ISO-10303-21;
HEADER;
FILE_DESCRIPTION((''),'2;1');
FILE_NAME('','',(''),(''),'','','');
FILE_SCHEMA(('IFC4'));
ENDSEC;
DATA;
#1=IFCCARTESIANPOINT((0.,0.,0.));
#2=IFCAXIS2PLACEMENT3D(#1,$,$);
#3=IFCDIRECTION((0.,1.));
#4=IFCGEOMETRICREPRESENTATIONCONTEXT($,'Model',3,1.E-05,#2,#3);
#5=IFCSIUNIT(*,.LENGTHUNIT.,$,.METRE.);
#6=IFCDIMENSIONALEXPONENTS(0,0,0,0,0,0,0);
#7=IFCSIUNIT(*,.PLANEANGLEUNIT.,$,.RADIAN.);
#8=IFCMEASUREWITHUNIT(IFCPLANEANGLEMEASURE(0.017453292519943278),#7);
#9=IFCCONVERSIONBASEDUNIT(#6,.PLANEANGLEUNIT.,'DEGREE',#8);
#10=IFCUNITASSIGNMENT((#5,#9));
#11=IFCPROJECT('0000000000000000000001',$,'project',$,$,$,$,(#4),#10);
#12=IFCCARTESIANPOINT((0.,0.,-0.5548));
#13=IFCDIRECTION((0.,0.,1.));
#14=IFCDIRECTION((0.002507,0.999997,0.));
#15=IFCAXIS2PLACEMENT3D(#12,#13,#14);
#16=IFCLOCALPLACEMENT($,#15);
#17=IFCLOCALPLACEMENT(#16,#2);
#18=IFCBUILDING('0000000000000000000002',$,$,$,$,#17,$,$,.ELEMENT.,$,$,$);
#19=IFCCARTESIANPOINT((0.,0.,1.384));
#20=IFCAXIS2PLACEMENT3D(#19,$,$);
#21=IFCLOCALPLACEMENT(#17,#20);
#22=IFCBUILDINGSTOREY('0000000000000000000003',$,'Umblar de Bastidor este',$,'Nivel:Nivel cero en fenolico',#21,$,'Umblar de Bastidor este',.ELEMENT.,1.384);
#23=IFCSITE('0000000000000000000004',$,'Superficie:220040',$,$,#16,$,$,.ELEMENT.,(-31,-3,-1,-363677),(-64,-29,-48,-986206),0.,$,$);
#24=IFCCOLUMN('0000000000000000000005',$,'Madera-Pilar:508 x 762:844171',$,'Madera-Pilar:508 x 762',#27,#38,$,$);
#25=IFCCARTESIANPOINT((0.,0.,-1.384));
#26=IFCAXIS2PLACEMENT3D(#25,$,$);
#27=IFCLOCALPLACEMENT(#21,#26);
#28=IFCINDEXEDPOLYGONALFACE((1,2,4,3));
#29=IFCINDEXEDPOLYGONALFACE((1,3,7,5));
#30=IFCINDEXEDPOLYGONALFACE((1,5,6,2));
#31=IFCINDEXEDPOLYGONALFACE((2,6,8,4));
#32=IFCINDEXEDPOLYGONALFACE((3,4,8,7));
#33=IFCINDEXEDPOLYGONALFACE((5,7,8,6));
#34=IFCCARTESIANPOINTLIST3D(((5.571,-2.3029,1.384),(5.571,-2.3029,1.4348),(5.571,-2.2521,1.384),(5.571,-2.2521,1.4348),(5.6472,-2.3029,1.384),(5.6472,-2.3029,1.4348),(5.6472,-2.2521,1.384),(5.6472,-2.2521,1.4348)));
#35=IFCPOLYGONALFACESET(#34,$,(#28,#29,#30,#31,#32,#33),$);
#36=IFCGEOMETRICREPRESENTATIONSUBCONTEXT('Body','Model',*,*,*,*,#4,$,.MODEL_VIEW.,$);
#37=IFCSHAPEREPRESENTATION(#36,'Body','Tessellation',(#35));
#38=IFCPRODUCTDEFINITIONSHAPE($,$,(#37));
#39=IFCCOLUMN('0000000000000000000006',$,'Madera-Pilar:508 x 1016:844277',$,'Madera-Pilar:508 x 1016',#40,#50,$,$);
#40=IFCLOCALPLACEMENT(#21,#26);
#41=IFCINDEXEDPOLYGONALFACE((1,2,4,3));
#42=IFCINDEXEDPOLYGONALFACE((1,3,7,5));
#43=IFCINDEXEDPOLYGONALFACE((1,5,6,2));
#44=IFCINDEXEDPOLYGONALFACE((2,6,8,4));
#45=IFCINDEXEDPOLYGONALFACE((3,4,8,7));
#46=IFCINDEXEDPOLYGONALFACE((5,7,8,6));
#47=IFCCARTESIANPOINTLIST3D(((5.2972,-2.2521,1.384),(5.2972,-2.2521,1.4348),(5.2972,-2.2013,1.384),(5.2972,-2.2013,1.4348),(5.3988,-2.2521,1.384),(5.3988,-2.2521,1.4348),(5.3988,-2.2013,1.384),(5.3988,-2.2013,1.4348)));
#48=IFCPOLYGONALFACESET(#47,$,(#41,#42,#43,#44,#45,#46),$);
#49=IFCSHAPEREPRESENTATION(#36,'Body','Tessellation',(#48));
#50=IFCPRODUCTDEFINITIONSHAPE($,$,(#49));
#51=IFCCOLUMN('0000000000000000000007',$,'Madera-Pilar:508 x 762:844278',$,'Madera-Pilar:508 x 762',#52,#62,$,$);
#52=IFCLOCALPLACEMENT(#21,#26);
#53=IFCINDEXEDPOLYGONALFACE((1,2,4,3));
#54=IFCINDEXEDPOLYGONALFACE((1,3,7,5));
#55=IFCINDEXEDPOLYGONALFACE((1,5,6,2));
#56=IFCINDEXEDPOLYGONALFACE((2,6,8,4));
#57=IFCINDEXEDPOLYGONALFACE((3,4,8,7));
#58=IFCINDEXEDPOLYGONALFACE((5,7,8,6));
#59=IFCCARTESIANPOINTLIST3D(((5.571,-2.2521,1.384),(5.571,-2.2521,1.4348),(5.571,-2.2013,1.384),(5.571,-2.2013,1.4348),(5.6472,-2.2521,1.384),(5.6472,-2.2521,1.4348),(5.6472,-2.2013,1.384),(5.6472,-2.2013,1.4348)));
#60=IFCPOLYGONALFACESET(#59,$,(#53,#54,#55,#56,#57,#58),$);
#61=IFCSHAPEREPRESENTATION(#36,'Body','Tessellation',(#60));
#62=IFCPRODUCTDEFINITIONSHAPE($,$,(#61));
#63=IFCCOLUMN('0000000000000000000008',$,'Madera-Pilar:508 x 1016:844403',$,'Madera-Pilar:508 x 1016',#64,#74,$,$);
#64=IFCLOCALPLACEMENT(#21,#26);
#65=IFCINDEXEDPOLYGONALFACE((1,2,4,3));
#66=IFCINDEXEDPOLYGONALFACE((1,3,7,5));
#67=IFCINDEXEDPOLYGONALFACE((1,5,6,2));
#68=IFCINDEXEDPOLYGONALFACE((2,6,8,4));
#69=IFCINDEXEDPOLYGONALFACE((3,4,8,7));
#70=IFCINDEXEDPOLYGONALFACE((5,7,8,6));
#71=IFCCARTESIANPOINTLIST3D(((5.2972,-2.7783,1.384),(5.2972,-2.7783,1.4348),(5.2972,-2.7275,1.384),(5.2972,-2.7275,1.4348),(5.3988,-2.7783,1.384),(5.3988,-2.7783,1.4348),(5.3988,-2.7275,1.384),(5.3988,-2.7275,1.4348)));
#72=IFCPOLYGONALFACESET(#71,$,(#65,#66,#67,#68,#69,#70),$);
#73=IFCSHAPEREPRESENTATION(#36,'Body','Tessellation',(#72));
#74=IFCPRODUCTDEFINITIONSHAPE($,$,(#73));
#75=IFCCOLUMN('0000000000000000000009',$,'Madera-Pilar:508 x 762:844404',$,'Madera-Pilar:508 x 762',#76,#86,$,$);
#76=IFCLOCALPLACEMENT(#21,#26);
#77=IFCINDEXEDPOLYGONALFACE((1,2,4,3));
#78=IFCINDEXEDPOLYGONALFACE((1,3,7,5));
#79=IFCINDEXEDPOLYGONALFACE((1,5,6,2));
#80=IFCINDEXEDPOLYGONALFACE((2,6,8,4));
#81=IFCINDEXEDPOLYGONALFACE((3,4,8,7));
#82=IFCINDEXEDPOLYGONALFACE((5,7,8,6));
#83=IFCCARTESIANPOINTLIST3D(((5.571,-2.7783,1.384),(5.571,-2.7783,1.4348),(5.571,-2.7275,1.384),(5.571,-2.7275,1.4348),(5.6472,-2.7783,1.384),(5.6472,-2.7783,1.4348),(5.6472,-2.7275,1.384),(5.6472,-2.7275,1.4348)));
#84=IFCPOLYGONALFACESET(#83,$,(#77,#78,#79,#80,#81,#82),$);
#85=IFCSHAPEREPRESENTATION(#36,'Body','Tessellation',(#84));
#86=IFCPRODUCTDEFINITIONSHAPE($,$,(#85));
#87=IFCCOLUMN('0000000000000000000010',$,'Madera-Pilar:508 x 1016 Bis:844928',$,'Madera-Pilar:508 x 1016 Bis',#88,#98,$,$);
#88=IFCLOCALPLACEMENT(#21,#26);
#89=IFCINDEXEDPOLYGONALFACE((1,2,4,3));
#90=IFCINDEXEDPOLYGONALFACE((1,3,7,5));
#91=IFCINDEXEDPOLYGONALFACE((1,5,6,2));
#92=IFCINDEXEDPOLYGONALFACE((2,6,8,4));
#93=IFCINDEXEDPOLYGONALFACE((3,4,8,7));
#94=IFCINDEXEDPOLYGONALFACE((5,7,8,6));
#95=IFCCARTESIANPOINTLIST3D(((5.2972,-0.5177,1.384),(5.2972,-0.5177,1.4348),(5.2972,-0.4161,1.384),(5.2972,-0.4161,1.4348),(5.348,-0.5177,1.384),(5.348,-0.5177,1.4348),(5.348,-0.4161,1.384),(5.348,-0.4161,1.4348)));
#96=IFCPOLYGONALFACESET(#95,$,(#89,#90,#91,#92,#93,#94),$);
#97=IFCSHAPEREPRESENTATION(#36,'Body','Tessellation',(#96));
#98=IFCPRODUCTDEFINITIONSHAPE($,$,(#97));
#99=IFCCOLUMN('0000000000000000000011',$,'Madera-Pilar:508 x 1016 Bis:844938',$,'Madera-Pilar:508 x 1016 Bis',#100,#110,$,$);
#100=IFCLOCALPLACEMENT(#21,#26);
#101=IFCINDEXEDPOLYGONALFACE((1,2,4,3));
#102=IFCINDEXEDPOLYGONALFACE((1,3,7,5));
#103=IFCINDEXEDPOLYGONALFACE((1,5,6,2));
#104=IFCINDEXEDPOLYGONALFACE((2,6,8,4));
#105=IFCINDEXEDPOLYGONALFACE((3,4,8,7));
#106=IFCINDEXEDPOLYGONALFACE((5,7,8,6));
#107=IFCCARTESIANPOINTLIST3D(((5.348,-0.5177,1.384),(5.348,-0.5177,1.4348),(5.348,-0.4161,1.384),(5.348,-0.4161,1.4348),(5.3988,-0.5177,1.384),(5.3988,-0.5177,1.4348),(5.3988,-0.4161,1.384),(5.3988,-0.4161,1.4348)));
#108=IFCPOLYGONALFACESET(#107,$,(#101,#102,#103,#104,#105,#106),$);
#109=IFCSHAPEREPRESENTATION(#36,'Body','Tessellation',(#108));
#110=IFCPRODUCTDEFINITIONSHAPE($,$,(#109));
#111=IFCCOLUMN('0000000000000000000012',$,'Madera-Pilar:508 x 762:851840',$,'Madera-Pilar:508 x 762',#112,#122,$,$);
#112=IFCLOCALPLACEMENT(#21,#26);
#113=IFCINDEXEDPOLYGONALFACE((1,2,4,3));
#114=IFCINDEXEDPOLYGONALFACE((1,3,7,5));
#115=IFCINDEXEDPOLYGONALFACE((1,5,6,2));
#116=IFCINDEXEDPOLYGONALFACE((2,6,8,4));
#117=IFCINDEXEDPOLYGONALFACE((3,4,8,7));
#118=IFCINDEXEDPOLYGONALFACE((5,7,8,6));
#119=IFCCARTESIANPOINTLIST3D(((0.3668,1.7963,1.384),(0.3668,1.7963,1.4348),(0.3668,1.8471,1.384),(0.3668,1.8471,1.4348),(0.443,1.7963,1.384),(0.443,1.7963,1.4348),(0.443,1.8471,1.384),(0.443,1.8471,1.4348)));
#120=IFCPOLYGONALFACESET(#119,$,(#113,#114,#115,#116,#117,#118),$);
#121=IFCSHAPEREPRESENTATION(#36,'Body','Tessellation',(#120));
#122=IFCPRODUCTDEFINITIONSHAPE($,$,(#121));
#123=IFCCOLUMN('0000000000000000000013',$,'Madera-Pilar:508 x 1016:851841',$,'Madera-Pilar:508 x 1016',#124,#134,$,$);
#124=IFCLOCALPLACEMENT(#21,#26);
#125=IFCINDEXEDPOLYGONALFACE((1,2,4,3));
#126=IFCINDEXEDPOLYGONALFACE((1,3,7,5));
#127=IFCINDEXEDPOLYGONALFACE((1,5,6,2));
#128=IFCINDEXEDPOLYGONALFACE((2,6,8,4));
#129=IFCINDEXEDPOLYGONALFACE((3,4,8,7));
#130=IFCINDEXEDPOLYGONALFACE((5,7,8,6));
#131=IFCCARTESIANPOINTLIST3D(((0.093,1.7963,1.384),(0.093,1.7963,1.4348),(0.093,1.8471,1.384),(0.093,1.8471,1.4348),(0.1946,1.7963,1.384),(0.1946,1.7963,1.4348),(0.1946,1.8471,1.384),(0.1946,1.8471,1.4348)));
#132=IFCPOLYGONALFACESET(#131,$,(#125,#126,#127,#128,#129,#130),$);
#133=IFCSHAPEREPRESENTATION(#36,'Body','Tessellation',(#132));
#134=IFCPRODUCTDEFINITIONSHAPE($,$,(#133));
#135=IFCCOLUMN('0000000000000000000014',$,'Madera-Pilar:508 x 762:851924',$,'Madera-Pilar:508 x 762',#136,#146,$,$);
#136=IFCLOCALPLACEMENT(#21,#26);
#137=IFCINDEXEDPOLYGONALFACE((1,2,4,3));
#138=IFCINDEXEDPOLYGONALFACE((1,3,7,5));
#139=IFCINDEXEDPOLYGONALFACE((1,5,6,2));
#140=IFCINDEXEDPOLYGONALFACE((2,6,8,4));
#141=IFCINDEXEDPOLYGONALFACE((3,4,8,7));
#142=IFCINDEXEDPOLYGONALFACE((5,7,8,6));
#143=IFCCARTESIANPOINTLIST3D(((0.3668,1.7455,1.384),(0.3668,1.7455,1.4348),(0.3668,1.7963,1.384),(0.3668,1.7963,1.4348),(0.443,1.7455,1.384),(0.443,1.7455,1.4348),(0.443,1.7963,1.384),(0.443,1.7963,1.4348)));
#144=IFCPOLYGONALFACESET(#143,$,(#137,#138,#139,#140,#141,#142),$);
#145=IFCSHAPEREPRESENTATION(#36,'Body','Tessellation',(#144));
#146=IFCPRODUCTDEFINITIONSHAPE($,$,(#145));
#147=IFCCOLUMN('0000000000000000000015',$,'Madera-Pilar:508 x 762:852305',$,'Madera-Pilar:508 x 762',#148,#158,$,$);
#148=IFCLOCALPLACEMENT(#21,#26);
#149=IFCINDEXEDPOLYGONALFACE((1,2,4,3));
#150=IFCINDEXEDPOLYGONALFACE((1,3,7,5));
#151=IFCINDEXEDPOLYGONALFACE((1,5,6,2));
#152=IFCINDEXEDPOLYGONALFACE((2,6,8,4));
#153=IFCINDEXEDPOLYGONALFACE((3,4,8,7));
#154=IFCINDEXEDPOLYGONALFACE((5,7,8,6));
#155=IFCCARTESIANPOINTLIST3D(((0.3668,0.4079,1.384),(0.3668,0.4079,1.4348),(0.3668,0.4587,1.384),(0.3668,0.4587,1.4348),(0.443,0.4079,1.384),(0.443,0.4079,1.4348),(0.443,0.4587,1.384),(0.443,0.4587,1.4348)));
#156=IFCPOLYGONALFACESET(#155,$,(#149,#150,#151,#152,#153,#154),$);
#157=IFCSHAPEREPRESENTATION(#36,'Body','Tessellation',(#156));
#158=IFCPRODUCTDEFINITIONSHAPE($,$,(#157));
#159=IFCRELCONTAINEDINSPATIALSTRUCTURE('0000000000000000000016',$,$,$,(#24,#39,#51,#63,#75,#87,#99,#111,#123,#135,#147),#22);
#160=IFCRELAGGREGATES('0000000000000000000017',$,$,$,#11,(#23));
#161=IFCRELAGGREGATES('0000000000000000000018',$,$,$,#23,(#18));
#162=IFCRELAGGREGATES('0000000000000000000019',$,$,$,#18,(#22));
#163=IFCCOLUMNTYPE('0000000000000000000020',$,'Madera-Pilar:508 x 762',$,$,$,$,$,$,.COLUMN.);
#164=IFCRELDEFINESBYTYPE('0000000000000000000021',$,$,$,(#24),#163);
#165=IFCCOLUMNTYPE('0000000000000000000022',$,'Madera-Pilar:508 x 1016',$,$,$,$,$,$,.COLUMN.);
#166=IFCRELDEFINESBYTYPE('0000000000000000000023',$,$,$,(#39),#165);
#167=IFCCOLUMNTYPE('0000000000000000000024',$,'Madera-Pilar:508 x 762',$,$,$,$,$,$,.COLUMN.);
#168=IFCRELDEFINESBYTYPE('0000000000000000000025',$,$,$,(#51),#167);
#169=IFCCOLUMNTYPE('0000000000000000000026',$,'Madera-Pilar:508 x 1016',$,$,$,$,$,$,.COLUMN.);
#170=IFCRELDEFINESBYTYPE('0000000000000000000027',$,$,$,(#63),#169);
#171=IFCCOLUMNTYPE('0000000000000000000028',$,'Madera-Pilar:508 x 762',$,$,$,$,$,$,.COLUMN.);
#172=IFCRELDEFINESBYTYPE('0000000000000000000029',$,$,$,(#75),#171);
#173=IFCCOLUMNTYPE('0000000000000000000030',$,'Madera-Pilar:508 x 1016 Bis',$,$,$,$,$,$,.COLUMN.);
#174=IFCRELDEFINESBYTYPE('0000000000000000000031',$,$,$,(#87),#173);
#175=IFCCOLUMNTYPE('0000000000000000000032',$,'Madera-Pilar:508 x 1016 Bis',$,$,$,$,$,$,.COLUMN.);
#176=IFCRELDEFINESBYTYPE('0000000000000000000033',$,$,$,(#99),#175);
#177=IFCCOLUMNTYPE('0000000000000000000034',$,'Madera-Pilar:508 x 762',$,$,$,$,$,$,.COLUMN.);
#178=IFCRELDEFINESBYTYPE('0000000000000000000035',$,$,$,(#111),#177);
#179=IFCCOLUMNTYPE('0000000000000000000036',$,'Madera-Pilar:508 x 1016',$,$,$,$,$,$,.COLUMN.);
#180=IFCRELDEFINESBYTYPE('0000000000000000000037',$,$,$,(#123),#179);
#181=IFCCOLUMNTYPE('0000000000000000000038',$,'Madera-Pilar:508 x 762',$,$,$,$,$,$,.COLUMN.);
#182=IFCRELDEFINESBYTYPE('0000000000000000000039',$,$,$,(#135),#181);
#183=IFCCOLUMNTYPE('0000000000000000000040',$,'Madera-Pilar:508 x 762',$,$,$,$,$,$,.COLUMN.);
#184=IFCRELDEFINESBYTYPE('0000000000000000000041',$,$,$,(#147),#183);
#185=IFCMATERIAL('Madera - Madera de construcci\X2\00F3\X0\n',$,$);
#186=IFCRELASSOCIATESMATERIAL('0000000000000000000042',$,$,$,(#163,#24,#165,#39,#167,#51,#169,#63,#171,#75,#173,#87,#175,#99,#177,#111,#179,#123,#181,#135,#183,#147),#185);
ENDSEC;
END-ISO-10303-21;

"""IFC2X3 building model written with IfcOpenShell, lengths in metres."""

from ifc_helpers import new_model, entity, si_unit, converted_unit, direction, frame, frame_2d, origin, origin_2d_with_axis, place, context, subcontext, project, spatial, rectangle, extrude, source, transform, mapped, material, type_object, type_shapes, element, save


model = new_model("IFC2X3")

# Units and contexts
model_context = context("Model", 3, precision=1e-05, world=origin(), true_north=direction((0.0, 1.0)))
body_context = subcontext(model_context, "Body", "Model", "MODEL_VIEW")
ifc_project = project(units=[si_unit("LENGTHUNIT", "METRE"), converted_unit("PLANEANGLEUNIT", "DEGREE", entity("IfcPlaneAngleMeasure", 0.017453292519943278), si_unit("PLANEANGLEUNIT", "RADIAN"), dimensions=[0, 0, 0, 0, 0, 0, 0])], contexts=[model_context])

# Site, building, storey
site_placement = place(None, frame((0.0, 0.0, -0.5548), z_axis=(0.0, 0.0, 1.0), x_axis=(0.002507, 0.999997, 0.0)))
site = spatial("IfcSite", under=ifc_project, at=site_placement, Name="Superficie:220040", CompositionType="ELEMENT", RefLatitude=(-31, -3, -1, -363677), RefLongitude=(-64, -29, -48, -986206), RefElevation=0.0)
building_placement = place(site_placement, origin())
building = spatial("IfcBuilding", under=site, at=building_placement, CompositionType="ELEMENT")
storey_placement = place(building_placement, frame((0.0, 0.0, 1.384)))
storey = spatial("IfcBuildingStorey", under=building, at=storey_placement, Name="Umblar de Bastidor este", ObjectType="Nivel:Nivel cero en fenolico", LongName="Umblar de Bastidor este", CompositionType="ELEMENT", Elevation=1.384)

# Columns
ifc_material = material(Name="Madera - Madera de construcción")
column_type_1 = type_object("IfcColumnType", Name="Madera-Pilar:508 x 762", PredefinedType="COLUMN", material=ifc_material)
shared_shape_1 = source(origin(), body_context, "Body", "SweptSolid", [
    extrude(rectangle(XDim=0.0762, YDim=0.0508, at=origin_2d_with_axis()), frame((5.6091, -2.2775, 1.384), z_axis=(0.0, 0.0, 1.0), x_axis=(-1.0, 0.0, 0.0)), (0.0, 0.0, 1.0), 0.0508),
])
type_shapes(column_type_1, [shared_shape_1])
column_1_placement = place(storey_placement, frame((0.0, 0.0, -1.384)))
element("IfcColumn", 1, at=column_1_placement, inside=storey, type_object=column_type_1, material=ifc_material, Name="Madera-Pilar:508 x 762:844171", ObjectType="Madera-Pilar:508 x 762", context=body_context, shape_type="MappedRepresentation", body=[
    mapped(shared_shape_1, transform((0.0, 0.0, 0.0), scale=1.0)),
])
column_type_2 = type_object("IfcColumnType", Name="Madera-Pilar:508 x 1016", PredefinedType="COLUMN", material=ifc_material)
shared_shape_2 = source(origin(), body_context, "Body", "SweptSolid", [
    extrude(rectangle(XDim=0.1016, YDim=0.0508, at=origin_2d_with_axis()), frame((5.348, -2.2267, 1.384), z_axis=(0.0, 0.0, 1.0), x_axis=(-1.0, 0.0, 0.0)), (0.0, 0.0, 1.0), 0.0508),
])
type_shapes(column_type_2, [shared_shape_2])
column_2_placement = place(storey_placement, frame((0.0, 0.0, -1.384)))
element("IfcColumn", 2, at=column_2_placement, inside=storey, type_object=column_type_2, material=ifc_material, Name="Madera-Pilar:508 x 1016:844277", ObjectType="Madera-Pilar:508 x 1016", context=body_context, shape_type="MappedRepresentation", body=[
    mapped(shared_shape_2, transform((0.0, 0.0, 0.0), scale=1.0)),
])
column_type_3 = type_object("IfcColumnType", Name="Madera-Pilar:508 x 762", PredefinedType="COLUMN", material=ifc_material)
shared_shape_3 = source(origin(), body_context, "Body", "SweptSolid", [
    extrude(rectangle(XDim=0.0762, YDim=0.0508, at=origin_2d_with_axis()), frame((5.6091, -2.2267, 1.384), z_axis=(0.0, 0.0, 1.0), x_axis=(-1.0, 0.0, 0.0)), (0.0, 0.0, 1.0), 0.0508),
])
type_shapes(column_type_3, [shared_shape_3])
column_3_placement = place(storey_placement, frame((0.0, 0.0, -1.384)))
element("IfcColumn", 3, at=column_3_placement, inside=storey, type_object=column_type_3, material=ifc_material, Name="Madera-Pilar:508 x 762:844278", ObjectType="Madera-Pilar:508 x 762", context=body_context, shape_type="MappedRepresentation", body=[
    mapped(shared_shape_3, transform((0.0, 0.0, 0.0), scale=1.0)),
])
column_type_4 = type_object("IfcColumnType", Name="Madera-Pilar:508 x 1016", PredefinedType="COLUMN", material=ifc_material)
shared_shape_4 = source(origin(), body_context, "Body", "SweptSolid", [
    extrude(rectangle(XDim=0.1016, YDim=0.0508, at=origin_2d_with_axis()), frame((5.348, -2.7529, 1.384), z_axis=(0.0, 0.0, 1.0), x_axis=(-1.0, 0.0, 0.0)), (0.0, 0.0, 1.0), 0.0508),
])
type_shapes(column_type_4, [shared_shape_4])
column_4_placement = place(storey_placement, frame((0.0, 0.0, -1.384)))
element("IfcColumn", 4, at=column_4_placement, inside=storey, type_object=column_type_4, material=ifc_material, Name="Madera-Pilar:508 x 1016:844403", ObjectType="Madera-Pilar:508 x 1016", context=body_context, shape_type="MappedRepresentation", body=[
    mapped(shared_shape_4, transform((0.0, 0.0, 0.0), scale=1.0)),
])
column_type_5 = type_object("IfcColumnType", Name="Madera-Pilar:508 x 762", PredefinedType="COLUMN", material=ifc_material)
shared_shape_5 = source(origin(), body_context, "Body", "SweptSolid", [
    extrude(rectangle(XDim=0.0762, YDim=0.0508, at=origin_2d_with_axis()), frame((5.6091, -2.7529, 1.384), z_axis=(0.0, 0.0, 1.0), x_axis=(-1.0, 0.0, 0.0)), (0.0, 0.0, 1.0), 0.0508),
])
type_shapes(column_type_5, [shared_shape_5])
column_5_placement = place(storey_placement, frame((0.0, 0.0, -1.384)))
element("IfcColumn", 5, at=column_5_placement, inside=storey, type_object=column_type_5, material=ifc_material, Name="Madera-Pilar:508 x 762:844404", ObjectType="Madera-Pilar:508 x 762", context=body_context, shape_type="MappedRepresentation", body=[
    mapped(shared_shape_5, transform((0.0, 0.0, 0.0), scale=1.0)),
])
column_type_6 = type_object("IfcColumnType", Name="Madera-Pilar:508 x 1016 Bis", PredefinedType="COLUMN", material=ifc_material)
shared_shape_6 = source(origin(), body_context, "Body", "SweptSolid", [
    extrude(rectangle(XDim=0.0508, YDim=0.1016, at=frame_2d((0.0, 0.0), x_axis=(1.0, 0.0))), frame((5.3226, -0.4669, 1.384)), (0.0, 0.0, 1.0), 0.0508),
])
type_shapes(column_type_6, [shared_shape_6])
column_6_placement = place(storey_placement, frame((0.0, 0.0, -1.384)))
element("IfcColumn", 6, at=column_6_placement, inside=storey, type_object=column_type_6, material=ifc_material, Name="Madera-Pilar:508 x 1016 Bis:844928", ObjectType="Madera-Pilar:508 x 1016 Bis", context=body_context, shape_type="MappedRepresentation", body=[
    mapped(shared_shape_6, transform((0.0, 0.0, 0.0), scale=1.0)),
])
column_type_7 = type_object("IfcColumnType", Name="Madera-Pilar:508 x 1016 Bis", PredefinedType="COLUMN", material=ifc_material)
shared_shape_7 = source(origin(), body_context, "Body", "SweptSolid", [
    extrude(rectangle(XDim=0.0508, YDim=0.1016, at=frame_2d((0.0, 0.0), x_axis=(1.0, 0.0))), frame((5.3734, -0.4669, 1.384)), (0.0, 0.0, 1.0), 0.0508),
])
type_shapes(column_type_7, [shared_shape_7])
column_7_placement = place(storey_placement, frame((0.0, 0.0, -1.384)))
element("IfcColumn", 7, at=column_7_placement, inside=storey, type_object=column_type_7, material=ifc_material, Name="Madera-Pilar:508 x 1016 Bis:844938", ObjectType="Madera-Pilar:508 x 1016 Bis", context=body_context, shape_type="MappedRepresentation", body=[
    mapped(shared_shape_7, transform((0.0, 0.0, 0.0), scale=1.0)),
])
column_type_8 = type_object("IfcColumnType", Name="Madera-Pilar:508 x 762", PredefinedType="COLUMN", material=ifc_material)
shared_shape_8 = source(origin(), body_context, "Body", "SweptSolid", [
    extrude(rectangle(XDim=0.0762, YDim=0.0508, at=origin_2d_with_axis()), frame((0.4049, 1.8217, 1.384), z_axis=(0.0, 0.0, 1.0), x_axis=(-1.0, 0.0, 0.0)), (0.0, 0.0, 1.0), 0.0508),
])
type_shapes(column_type_8, [shared_shape_8])
column_8_placement = place(storey_placement, frame((0.0, 0.0, -1.384)))
element("IfcColumn", 8, at=column_8_placement, inside=storey, type_object=column_type_8, material=ifc_material, Name="Madera-Pilar:508 x 762:851840", ObjectType="Madera-Pilar:508 x 762", context=body_context, shape_type="MappedRepresentation", body=[
    mapped(shared_shape_8, transform((0.0, 0.0, 0.0), scale=1.0)),
])
column_type_9 = type_object("IfcColumnType", Name="Madera-Pilar:508 x 1016", PredefinedType="COLUMN", material=ifc_material)
shared_shape_9 = source(origin(), body_context, "Body", "SweptSolid", [
    extrude(rectangle(XDim=0.1016, YDim=0.0508, at=frame_2d((0.0, 0.0), x_axis=(1.0, 0.0))), frame((0.1438, 1.8217, 1.384), z_axis=(0.0, 0.0, 1.0), x_axis=(-1.0, 0.0, 0.0)), (0.0, 0.0, 1.0), 0.0508),
])
type_shapes(column_type_9, [shared_shape_9])
column_9_placement = place(storey_placement, frame((0.0, 0.0, -1.384)))
element("IfcColumn", 9, at=column_9_placement, inside=storey, type_object=column_type_9, material=ifc_material, Name="Madera-Pilar:508 x 1016:851841", ObjectType="Madera-Pilar:508 x 1016", context=body_context, shape_type="MappedRepresentation", body=[
    mapped(shared_shape_9, transform((0.0, 0.0, 0.0), scale=1.0)),
])
column_type_10 = type_object("IfcColumnType", Name="Madera-Pilar:508 x 762", PredefinedType="COLUMN", material=ifc_material)
shared_shape_10 = source(origin(), body_context, "Body", "SweptSolid", [
    extrude(rectangle(XDim=0.0762, YDim=0.0508, at=origin_2d_with_axis()), frame((0.4049, 1.7709, 1.384), z_axis=(0.0, 0.0, 1.0), x_axis=(-1.0, 0.0, 0.0)), (0.0, 0.0, 1.0), 0.0508),
])
type_shapes(column_type_10, [shared_shape_10])
column_10_placement = place(storey_placement, frame((0.0, 0.0, -1.384)))
element("IfcColumn", 10, at=column_10_placement, inside=storey, type_object=column_type_10, material=ifc_material, Name="Madera-Pilar:508 x 762:851924", ObjectType="Madera-Pilar:508 x 762", context=body_context, shape_type="MappedRepresentation", body=[
    mapped(shared_shape_10, transform((0.0, 0.0, 0.0), scale=1.0)),
])
column_type_11 = type_object("IfcColumnType", Name="Madera-Pilar:508 x 762", PredefinedType="COLUMN", material=ifc_material)
shared_shape_11 = source(origin(), body_context, "Body", "SweptSolid", [
    extrude(rectangle(XDim=0.0762, YDim=0.0508, at=origin_2d_with_axis()), frame((0.4049, 0.4333, 1.384), z_axis=(0.0, 0.0, 1.0), x_axis=(-1.0, 0.0, 0.0)), (0.0, 0.0, 1.0), 0.0508),
])
type_shapes(column_type_11, [shared_shape_11])
column_11_placement = place(storey_placement, frame((0.0, 0.0, -1.384)))
element("IfcColumn", 11, at=column_11_placement, inside=storey, type_object=column_type_11, material=ifc_material, Name="Madera-Pilar:508 x 762:852305", ObjectType="Madera-Pilar:508 x 762", context=body_context, shape_type="MappedRepresentation", body=[
    mapped(shared_shape_11, transform((0.0, 0.0, 0.0), scale=1.0)),
])

save(model, "model.ifc")
